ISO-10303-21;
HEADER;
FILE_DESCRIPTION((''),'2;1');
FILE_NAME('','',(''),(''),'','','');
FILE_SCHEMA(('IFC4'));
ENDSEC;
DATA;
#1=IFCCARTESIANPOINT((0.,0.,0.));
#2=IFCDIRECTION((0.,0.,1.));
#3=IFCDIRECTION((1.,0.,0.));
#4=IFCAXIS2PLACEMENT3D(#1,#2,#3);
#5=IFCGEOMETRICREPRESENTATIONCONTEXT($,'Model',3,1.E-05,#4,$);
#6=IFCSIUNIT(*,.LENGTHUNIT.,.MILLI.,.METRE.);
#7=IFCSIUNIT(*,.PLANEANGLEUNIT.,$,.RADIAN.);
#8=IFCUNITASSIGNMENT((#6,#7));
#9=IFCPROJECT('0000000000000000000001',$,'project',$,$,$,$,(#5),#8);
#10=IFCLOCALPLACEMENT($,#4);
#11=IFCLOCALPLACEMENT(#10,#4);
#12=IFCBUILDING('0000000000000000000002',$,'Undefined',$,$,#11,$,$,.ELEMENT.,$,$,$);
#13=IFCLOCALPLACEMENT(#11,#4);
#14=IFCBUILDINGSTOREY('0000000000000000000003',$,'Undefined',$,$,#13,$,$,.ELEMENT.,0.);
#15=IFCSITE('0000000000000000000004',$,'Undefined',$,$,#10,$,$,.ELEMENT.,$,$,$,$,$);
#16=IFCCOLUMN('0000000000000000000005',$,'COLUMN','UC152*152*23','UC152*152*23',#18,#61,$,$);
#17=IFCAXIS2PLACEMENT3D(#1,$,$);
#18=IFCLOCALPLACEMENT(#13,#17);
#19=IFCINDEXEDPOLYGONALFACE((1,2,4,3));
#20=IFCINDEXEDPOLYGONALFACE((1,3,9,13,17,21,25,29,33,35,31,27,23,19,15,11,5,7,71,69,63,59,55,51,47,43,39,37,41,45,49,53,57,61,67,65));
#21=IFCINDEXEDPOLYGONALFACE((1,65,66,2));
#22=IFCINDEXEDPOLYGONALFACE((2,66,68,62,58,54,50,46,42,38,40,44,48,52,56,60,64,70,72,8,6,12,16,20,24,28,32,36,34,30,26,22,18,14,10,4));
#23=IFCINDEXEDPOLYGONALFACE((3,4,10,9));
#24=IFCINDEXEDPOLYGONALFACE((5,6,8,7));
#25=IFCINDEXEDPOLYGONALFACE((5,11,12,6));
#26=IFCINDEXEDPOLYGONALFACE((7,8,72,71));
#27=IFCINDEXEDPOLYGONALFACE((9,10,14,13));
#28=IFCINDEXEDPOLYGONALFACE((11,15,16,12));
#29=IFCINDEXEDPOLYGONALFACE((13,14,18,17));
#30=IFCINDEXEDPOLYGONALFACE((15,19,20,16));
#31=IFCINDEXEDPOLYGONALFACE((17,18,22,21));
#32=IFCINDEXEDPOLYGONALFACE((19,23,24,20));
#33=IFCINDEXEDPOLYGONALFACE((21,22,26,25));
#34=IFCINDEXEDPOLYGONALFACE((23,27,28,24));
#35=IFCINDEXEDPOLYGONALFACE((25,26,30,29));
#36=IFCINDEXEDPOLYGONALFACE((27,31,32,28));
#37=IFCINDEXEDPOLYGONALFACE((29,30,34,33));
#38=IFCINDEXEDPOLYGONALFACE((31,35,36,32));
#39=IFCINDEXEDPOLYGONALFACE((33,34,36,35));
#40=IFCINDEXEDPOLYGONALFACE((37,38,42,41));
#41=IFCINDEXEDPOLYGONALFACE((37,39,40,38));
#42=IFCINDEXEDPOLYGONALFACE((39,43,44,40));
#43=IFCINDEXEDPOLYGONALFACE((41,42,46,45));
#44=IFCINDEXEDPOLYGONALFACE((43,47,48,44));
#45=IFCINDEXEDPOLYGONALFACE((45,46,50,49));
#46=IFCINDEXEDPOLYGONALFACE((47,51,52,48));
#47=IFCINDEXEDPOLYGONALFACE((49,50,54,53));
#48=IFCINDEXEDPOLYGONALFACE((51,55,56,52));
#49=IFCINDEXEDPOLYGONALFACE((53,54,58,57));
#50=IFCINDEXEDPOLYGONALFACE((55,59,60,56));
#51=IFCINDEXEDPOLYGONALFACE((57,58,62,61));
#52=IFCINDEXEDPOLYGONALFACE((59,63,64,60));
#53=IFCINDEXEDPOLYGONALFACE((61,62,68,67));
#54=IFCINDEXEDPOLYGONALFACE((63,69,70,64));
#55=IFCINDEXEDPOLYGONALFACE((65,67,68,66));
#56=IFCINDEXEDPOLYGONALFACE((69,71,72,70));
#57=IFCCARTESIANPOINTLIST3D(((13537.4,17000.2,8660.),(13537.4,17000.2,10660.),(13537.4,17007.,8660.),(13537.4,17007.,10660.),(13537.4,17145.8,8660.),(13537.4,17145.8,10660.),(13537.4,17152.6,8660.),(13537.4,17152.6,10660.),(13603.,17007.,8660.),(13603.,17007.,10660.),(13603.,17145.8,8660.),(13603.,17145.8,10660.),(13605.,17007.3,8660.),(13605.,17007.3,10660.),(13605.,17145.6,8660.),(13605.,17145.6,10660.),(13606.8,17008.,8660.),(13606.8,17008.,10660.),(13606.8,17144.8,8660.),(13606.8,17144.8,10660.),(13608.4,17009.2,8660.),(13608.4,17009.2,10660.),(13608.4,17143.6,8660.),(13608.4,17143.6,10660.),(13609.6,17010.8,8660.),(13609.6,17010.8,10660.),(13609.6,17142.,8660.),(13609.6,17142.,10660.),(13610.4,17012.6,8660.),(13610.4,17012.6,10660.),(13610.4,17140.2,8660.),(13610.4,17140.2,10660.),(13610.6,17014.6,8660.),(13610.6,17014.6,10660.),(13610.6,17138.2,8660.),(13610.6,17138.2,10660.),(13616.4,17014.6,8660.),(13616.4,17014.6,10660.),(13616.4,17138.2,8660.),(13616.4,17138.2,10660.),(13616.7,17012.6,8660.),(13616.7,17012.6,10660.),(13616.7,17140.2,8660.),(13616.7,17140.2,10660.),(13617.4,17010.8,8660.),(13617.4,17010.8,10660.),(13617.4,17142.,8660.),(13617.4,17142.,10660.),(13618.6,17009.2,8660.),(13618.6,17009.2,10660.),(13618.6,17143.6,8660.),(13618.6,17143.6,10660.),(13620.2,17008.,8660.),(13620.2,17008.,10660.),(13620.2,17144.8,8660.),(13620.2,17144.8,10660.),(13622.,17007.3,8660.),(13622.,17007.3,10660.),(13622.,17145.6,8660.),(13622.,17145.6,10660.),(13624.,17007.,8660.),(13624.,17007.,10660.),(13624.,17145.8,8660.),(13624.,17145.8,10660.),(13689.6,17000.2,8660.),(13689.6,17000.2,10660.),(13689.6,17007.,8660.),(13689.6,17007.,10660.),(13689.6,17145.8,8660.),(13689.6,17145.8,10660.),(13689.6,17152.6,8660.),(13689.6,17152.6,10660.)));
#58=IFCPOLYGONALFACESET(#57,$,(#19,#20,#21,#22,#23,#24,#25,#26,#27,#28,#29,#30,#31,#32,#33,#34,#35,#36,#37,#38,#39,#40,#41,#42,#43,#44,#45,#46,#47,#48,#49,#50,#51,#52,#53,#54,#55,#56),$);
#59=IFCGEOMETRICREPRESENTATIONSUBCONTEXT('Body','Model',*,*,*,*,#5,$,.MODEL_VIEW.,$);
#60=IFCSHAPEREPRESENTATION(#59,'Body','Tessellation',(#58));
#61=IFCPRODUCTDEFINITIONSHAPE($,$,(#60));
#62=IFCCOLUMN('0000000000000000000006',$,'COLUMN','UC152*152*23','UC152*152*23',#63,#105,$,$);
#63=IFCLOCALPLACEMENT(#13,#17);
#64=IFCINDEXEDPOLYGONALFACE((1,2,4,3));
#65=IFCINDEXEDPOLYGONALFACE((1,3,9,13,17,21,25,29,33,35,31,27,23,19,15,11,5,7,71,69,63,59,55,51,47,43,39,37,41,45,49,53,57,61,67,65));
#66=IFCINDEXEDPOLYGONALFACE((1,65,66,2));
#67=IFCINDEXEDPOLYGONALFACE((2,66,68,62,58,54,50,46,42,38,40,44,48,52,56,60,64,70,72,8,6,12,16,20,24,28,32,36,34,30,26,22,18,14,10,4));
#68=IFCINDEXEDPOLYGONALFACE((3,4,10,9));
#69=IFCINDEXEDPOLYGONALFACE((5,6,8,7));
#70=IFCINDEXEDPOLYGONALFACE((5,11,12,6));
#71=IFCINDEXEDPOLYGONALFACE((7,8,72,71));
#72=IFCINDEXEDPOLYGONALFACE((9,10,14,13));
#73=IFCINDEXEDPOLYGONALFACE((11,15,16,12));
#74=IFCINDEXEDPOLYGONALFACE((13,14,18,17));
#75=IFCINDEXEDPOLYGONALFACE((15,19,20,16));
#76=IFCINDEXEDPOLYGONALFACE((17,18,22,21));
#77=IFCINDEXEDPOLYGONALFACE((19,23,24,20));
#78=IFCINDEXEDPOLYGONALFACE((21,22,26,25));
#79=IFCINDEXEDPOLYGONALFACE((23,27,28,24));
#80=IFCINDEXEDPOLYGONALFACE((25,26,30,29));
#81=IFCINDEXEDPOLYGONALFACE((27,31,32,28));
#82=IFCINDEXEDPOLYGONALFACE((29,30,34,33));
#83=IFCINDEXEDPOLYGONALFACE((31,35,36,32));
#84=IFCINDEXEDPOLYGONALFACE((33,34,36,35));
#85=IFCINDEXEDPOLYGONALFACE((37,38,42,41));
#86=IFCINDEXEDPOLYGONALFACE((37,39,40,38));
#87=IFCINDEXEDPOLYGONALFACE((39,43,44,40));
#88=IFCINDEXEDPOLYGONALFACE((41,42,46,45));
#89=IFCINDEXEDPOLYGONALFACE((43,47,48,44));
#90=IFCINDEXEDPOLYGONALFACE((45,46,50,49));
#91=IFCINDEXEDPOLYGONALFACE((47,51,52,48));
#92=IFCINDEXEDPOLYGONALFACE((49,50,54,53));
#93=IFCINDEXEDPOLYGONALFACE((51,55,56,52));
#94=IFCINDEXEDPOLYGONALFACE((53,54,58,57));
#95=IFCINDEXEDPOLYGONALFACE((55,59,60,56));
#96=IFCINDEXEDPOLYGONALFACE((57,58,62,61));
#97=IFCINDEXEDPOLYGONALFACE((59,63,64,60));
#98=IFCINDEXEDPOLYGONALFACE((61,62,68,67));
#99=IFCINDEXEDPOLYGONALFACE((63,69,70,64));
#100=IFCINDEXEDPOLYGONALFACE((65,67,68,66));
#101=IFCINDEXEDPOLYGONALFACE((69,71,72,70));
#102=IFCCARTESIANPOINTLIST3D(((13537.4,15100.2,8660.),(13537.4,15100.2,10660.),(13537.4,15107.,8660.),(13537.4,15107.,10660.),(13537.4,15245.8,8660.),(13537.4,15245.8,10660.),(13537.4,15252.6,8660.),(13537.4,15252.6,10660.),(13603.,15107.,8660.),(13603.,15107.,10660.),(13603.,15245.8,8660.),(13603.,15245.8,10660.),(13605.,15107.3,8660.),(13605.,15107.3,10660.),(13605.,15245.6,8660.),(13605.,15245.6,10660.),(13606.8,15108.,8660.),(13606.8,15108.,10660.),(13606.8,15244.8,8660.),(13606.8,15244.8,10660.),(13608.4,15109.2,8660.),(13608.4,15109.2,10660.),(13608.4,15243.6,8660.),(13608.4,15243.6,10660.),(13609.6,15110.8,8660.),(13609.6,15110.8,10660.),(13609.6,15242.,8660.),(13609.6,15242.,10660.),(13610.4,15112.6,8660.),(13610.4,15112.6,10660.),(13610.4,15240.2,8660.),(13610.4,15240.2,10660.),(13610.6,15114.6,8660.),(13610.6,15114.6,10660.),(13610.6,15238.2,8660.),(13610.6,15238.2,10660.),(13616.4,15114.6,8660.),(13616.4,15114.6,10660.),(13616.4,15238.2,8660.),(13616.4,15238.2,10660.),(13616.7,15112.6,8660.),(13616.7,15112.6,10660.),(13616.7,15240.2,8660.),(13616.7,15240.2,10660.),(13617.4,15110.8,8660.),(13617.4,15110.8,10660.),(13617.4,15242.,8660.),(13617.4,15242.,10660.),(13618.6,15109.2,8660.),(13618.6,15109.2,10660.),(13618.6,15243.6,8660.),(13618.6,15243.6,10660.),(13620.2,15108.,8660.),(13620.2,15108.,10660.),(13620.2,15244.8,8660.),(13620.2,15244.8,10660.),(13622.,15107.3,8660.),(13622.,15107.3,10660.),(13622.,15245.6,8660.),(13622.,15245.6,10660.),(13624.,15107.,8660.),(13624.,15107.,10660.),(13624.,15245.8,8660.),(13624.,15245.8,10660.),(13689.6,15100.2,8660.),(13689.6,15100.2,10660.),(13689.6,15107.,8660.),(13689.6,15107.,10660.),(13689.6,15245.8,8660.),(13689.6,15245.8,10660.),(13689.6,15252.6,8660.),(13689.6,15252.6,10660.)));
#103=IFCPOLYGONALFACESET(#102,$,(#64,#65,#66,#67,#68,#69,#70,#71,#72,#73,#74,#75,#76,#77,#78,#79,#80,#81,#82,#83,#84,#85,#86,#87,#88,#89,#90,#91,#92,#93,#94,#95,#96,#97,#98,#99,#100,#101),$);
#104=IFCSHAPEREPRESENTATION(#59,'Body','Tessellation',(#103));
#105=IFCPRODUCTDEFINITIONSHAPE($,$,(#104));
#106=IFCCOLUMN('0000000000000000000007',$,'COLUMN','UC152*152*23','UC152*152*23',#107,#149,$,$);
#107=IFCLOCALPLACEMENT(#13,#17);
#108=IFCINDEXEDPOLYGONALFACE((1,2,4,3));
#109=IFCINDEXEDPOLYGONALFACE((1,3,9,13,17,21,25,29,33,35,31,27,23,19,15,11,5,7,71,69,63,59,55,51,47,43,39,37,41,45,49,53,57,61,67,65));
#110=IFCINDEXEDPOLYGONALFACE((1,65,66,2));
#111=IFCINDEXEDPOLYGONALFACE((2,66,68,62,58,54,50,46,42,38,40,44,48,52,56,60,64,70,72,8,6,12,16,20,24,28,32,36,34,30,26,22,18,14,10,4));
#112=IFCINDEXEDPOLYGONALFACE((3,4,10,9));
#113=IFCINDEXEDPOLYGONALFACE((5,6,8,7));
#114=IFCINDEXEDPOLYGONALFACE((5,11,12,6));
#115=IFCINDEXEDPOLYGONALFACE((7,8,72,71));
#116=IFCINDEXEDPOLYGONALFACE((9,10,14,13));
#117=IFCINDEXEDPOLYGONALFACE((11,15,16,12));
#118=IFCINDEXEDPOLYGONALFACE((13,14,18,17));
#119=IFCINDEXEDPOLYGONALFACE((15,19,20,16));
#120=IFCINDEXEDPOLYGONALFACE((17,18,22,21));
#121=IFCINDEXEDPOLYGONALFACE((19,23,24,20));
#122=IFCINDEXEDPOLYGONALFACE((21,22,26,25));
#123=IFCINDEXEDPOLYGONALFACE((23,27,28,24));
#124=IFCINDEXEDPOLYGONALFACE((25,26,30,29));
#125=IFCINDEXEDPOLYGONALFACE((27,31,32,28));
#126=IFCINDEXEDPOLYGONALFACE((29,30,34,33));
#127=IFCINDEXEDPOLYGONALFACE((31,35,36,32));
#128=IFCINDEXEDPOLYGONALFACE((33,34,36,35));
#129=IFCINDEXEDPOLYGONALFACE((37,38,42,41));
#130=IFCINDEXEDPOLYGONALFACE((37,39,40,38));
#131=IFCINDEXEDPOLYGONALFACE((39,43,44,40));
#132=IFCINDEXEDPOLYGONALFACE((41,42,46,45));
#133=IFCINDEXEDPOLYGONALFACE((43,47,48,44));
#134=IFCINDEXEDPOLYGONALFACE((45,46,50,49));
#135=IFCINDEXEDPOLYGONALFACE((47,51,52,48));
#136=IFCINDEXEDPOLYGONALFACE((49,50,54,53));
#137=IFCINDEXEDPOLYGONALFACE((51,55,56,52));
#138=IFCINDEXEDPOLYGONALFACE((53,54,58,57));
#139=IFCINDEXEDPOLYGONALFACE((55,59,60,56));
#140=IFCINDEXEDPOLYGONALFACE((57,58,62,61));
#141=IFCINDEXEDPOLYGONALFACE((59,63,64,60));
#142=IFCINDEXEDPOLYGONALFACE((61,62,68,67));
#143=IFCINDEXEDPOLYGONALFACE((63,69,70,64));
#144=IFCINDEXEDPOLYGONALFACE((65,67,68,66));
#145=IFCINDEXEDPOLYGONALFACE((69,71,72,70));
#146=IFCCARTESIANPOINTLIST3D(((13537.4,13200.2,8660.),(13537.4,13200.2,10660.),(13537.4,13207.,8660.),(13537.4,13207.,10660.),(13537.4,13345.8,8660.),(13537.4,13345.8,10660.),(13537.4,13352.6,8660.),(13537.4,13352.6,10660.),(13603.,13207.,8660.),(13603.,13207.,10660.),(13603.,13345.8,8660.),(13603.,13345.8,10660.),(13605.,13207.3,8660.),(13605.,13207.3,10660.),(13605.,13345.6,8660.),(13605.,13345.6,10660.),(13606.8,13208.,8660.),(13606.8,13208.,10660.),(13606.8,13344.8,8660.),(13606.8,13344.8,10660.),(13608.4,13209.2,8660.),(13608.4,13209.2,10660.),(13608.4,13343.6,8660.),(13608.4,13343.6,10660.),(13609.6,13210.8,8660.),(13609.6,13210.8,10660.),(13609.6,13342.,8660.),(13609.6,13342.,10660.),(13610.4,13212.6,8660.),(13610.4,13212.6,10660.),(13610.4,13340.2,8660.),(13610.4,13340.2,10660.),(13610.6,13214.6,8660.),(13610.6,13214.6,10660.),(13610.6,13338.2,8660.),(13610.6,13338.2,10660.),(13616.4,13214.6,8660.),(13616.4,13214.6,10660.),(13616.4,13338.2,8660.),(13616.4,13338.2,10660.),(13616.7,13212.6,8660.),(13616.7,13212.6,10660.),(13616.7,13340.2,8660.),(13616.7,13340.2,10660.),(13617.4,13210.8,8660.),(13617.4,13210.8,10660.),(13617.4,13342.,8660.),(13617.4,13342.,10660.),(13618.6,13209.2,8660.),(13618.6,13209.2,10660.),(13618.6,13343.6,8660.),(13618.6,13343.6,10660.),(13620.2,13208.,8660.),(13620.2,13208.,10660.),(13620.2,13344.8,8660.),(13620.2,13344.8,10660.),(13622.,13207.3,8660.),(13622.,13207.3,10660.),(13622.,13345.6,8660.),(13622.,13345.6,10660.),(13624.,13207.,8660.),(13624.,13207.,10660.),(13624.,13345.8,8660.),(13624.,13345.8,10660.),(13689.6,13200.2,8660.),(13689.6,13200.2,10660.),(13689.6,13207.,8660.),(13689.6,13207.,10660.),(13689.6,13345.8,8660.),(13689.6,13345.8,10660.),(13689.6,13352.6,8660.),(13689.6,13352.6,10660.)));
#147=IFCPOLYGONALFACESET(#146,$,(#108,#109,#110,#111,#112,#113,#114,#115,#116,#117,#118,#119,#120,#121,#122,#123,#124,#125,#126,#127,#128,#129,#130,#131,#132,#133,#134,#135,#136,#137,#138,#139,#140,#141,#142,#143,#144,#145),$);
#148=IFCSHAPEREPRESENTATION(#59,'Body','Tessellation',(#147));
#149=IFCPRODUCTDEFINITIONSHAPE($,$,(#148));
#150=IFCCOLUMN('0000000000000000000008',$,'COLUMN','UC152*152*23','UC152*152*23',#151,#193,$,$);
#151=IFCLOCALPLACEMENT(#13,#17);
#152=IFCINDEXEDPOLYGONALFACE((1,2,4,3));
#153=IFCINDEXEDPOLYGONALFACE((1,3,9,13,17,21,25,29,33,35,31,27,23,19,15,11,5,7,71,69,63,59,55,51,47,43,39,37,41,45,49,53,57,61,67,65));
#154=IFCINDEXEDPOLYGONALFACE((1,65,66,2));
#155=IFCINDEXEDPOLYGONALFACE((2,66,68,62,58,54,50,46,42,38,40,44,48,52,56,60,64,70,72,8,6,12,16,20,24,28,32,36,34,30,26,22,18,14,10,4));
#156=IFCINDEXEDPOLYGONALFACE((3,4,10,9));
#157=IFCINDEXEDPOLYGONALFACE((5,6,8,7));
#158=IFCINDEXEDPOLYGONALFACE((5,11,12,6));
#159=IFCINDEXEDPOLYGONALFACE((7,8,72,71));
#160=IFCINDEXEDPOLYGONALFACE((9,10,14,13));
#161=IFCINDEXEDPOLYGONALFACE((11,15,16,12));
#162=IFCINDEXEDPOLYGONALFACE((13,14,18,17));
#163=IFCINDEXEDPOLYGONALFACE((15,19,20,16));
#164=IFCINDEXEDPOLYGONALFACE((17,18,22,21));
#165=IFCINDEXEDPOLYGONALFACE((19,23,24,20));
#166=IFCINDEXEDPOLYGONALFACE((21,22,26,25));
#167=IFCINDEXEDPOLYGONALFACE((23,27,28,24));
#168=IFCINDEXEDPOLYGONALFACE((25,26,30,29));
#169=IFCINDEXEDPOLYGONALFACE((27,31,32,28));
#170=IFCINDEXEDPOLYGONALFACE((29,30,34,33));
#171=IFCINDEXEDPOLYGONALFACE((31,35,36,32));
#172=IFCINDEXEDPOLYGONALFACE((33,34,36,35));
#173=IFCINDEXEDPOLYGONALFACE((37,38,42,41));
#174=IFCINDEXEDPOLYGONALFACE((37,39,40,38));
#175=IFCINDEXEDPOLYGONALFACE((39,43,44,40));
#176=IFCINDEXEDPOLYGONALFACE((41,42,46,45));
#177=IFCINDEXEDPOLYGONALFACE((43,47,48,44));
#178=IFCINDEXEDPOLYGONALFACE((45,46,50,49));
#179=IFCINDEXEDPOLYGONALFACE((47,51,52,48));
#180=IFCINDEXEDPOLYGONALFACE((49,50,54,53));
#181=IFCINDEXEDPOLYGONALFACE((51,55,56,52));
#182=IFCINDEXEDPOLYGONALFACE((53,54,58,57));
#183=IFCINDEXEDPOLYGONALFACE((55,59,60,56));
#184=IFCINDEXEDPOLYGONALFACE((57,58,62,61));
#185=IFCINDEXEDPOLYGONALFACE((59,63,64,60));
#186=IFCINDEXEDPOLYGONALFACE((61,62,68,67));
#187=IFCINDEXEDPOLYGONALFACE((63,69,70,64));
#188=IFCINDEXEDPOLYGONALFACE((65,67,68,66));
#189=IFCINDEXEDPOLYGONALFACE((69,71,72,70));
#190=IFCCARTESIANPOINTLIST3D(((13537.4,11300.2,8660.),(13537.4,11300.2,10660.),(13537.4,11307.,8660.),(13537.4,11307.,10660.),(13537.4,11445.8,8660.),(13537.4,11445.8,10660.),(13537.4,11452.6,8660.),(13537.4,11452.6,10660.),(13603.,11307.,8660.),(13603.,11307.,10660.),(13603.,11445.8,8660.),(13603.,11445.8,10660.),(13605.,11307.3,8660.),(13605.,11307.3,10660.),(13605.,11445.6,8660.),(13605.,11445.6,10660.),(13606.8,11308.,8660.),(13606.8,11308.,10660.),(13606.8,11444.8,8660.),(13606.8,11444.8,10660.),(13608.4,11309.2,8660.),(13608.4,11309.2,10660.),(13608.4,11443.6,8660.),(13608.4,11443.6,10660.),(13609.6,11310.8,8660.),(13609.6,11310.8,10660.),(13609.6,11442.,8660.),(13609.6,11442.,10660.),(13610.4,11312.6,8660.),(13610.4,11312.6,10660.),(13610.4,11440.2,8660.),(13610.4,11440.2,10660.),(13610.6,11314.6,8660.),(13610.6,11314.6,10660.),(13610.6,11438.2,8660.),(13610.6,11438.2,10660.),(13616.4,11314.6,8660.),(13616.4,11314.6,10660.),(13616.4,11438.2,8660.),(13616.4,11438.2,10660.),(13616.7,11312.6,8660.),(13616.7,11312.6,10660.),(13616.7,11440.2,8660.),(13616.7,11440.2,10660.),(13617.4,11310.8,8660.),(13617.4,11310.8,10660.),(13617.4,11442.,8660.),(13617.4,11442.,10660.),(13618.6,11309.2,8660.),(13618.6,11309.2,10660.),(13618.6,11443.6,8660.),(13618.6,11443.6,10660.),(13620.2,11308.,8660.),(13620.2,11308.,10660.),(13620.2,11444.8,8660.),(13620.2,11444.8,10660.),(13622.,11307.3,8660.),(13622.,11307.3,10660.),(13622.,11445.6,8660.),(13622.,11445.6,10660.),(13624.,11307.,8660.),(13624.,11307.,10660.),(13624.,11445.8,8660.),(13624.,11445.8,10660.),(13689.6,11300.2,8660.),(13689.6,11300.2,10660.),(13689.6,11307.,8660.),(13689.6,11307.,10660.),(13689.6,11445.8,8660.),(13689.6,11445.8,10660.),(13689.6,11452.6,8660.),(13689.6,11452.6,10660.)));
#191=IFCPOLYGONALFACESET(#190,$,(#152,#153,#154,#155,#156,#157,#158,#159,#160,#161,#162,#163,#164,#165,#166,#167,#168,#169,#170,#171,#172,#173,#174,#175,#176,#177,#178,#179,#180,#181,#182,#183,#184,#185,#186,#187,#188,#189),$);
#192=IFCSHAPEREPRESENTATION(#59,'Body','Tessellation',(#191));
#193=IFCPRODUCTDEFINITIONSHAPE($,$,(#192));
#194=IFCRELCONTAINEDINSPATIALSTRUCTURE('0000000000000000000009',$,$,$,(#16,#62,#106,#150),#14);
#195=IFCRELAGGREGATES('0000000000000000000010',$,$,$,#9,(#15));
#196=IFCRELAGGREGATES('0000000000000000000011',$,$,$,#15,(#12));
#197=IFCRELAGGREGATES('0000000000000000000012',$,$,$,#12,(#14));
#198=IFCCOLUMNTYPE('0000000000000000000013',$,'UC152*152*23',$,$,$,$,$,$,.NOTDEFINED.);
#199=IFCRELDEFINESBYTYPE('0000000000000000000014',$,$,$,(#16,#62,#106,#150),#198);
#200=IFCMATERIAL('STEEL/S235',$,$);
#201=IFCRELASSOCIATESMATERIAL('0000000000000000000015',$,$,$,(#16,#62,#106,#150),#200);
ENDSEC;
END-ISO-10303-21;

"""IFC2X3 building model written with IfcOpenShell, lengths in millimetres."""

from ifc_helpers import new_model, si_unit, frame, origin_with_axes, origin_2d_with_axis, place, context, subcontext, project, spatial, i_section, extrude, material, type_object, element, save


model = new_model("IFC2X3")

# Units and contexts
model_context = context("Model", 3, precision=1e-05, world=origin_with_axes())
body_context = subcontext(model_context, "Body", "Model", "MODEL_VIEW")
ifc_project = project(units=[si_unit("LENGTHUNIT", "METRE", prefix="MILLI"), si_unit("PLANEANGLEUNIT", "RADIAN")], contexts=[model_context])

# Site, building, storey
site_placement = place(None, origin_with_axes())
site = spatial("IfcSite", under=ifc_project, at=site_placement, Name="Undefined", CompositionType="ELEMENT")
building_placement = place(site_placement, origin_with_axes())
building = spatial("IfcBuilding", under=site, at=building_placement, Name="Undefined", CompositionType="ELEMENT")
storey_placement = place(building_placement, origin_with_axes())
storey = spatial("IfcBuildingStorey", under=building, at=storey_placement, Name="Undefined", CompositionType="ELEMENT", Elevation=0.0)

# Columns
ifc_material = material(Name="STEEL/S235")
column_type = type_object("IfcColumnType", Name="UC152*152*23", PredefinedType="NOTDEFINED")
for number, where, z_axis, x_axis, name in (
    (1, (13613.5, 17076.4, 8660.0), (0.0, 0.0, 1.0), (0.0, -1.0, 0.0), "COLUMN"),
    (2, (13613.5, 15176.4, 8660.0), (0.0, 0.0, 1.0), (0.0, -1.0, 0.0), "COLUMN"),
    (3, (13613.5, 13276.4, 8660.0), (0.0, 0.0, 1.0), (0.0, -1.0, 0.0), "COLUMN"),
    (4, (13613.5, 11376.4, 8660.0), (0.0, 0.0, 1.0), (0.0, -1.0, 0.0), "COLUMN"),
):
    element("IfcColumn", number, at=place(storey_placement, frame(where, z_axis=z_axis, x_axis=x_axis)), inside=storey, type_object=column_type, material=ifc_material, Name=name, Description="UC152*152*23", ObjectType="UC152*152*23", context=body_context, shape_type="SweptSolid", body=[
        extrude(i_section(OverallWidth=152.2, OverallDepth=152.4, WebThickness=5.8, FlangeThickness=6.8, FilletRadius=7.6, at=origin_2d_with_axis()), frame((0.0, 0.0, 2000.0), z_axis=(0.0, 0.0, -1.0), x_axis=(0.0, 1.0, 0.0)), (0.0, 0.0, 1.0), 2000.0),
    ])

save(model, "model.ifc")
